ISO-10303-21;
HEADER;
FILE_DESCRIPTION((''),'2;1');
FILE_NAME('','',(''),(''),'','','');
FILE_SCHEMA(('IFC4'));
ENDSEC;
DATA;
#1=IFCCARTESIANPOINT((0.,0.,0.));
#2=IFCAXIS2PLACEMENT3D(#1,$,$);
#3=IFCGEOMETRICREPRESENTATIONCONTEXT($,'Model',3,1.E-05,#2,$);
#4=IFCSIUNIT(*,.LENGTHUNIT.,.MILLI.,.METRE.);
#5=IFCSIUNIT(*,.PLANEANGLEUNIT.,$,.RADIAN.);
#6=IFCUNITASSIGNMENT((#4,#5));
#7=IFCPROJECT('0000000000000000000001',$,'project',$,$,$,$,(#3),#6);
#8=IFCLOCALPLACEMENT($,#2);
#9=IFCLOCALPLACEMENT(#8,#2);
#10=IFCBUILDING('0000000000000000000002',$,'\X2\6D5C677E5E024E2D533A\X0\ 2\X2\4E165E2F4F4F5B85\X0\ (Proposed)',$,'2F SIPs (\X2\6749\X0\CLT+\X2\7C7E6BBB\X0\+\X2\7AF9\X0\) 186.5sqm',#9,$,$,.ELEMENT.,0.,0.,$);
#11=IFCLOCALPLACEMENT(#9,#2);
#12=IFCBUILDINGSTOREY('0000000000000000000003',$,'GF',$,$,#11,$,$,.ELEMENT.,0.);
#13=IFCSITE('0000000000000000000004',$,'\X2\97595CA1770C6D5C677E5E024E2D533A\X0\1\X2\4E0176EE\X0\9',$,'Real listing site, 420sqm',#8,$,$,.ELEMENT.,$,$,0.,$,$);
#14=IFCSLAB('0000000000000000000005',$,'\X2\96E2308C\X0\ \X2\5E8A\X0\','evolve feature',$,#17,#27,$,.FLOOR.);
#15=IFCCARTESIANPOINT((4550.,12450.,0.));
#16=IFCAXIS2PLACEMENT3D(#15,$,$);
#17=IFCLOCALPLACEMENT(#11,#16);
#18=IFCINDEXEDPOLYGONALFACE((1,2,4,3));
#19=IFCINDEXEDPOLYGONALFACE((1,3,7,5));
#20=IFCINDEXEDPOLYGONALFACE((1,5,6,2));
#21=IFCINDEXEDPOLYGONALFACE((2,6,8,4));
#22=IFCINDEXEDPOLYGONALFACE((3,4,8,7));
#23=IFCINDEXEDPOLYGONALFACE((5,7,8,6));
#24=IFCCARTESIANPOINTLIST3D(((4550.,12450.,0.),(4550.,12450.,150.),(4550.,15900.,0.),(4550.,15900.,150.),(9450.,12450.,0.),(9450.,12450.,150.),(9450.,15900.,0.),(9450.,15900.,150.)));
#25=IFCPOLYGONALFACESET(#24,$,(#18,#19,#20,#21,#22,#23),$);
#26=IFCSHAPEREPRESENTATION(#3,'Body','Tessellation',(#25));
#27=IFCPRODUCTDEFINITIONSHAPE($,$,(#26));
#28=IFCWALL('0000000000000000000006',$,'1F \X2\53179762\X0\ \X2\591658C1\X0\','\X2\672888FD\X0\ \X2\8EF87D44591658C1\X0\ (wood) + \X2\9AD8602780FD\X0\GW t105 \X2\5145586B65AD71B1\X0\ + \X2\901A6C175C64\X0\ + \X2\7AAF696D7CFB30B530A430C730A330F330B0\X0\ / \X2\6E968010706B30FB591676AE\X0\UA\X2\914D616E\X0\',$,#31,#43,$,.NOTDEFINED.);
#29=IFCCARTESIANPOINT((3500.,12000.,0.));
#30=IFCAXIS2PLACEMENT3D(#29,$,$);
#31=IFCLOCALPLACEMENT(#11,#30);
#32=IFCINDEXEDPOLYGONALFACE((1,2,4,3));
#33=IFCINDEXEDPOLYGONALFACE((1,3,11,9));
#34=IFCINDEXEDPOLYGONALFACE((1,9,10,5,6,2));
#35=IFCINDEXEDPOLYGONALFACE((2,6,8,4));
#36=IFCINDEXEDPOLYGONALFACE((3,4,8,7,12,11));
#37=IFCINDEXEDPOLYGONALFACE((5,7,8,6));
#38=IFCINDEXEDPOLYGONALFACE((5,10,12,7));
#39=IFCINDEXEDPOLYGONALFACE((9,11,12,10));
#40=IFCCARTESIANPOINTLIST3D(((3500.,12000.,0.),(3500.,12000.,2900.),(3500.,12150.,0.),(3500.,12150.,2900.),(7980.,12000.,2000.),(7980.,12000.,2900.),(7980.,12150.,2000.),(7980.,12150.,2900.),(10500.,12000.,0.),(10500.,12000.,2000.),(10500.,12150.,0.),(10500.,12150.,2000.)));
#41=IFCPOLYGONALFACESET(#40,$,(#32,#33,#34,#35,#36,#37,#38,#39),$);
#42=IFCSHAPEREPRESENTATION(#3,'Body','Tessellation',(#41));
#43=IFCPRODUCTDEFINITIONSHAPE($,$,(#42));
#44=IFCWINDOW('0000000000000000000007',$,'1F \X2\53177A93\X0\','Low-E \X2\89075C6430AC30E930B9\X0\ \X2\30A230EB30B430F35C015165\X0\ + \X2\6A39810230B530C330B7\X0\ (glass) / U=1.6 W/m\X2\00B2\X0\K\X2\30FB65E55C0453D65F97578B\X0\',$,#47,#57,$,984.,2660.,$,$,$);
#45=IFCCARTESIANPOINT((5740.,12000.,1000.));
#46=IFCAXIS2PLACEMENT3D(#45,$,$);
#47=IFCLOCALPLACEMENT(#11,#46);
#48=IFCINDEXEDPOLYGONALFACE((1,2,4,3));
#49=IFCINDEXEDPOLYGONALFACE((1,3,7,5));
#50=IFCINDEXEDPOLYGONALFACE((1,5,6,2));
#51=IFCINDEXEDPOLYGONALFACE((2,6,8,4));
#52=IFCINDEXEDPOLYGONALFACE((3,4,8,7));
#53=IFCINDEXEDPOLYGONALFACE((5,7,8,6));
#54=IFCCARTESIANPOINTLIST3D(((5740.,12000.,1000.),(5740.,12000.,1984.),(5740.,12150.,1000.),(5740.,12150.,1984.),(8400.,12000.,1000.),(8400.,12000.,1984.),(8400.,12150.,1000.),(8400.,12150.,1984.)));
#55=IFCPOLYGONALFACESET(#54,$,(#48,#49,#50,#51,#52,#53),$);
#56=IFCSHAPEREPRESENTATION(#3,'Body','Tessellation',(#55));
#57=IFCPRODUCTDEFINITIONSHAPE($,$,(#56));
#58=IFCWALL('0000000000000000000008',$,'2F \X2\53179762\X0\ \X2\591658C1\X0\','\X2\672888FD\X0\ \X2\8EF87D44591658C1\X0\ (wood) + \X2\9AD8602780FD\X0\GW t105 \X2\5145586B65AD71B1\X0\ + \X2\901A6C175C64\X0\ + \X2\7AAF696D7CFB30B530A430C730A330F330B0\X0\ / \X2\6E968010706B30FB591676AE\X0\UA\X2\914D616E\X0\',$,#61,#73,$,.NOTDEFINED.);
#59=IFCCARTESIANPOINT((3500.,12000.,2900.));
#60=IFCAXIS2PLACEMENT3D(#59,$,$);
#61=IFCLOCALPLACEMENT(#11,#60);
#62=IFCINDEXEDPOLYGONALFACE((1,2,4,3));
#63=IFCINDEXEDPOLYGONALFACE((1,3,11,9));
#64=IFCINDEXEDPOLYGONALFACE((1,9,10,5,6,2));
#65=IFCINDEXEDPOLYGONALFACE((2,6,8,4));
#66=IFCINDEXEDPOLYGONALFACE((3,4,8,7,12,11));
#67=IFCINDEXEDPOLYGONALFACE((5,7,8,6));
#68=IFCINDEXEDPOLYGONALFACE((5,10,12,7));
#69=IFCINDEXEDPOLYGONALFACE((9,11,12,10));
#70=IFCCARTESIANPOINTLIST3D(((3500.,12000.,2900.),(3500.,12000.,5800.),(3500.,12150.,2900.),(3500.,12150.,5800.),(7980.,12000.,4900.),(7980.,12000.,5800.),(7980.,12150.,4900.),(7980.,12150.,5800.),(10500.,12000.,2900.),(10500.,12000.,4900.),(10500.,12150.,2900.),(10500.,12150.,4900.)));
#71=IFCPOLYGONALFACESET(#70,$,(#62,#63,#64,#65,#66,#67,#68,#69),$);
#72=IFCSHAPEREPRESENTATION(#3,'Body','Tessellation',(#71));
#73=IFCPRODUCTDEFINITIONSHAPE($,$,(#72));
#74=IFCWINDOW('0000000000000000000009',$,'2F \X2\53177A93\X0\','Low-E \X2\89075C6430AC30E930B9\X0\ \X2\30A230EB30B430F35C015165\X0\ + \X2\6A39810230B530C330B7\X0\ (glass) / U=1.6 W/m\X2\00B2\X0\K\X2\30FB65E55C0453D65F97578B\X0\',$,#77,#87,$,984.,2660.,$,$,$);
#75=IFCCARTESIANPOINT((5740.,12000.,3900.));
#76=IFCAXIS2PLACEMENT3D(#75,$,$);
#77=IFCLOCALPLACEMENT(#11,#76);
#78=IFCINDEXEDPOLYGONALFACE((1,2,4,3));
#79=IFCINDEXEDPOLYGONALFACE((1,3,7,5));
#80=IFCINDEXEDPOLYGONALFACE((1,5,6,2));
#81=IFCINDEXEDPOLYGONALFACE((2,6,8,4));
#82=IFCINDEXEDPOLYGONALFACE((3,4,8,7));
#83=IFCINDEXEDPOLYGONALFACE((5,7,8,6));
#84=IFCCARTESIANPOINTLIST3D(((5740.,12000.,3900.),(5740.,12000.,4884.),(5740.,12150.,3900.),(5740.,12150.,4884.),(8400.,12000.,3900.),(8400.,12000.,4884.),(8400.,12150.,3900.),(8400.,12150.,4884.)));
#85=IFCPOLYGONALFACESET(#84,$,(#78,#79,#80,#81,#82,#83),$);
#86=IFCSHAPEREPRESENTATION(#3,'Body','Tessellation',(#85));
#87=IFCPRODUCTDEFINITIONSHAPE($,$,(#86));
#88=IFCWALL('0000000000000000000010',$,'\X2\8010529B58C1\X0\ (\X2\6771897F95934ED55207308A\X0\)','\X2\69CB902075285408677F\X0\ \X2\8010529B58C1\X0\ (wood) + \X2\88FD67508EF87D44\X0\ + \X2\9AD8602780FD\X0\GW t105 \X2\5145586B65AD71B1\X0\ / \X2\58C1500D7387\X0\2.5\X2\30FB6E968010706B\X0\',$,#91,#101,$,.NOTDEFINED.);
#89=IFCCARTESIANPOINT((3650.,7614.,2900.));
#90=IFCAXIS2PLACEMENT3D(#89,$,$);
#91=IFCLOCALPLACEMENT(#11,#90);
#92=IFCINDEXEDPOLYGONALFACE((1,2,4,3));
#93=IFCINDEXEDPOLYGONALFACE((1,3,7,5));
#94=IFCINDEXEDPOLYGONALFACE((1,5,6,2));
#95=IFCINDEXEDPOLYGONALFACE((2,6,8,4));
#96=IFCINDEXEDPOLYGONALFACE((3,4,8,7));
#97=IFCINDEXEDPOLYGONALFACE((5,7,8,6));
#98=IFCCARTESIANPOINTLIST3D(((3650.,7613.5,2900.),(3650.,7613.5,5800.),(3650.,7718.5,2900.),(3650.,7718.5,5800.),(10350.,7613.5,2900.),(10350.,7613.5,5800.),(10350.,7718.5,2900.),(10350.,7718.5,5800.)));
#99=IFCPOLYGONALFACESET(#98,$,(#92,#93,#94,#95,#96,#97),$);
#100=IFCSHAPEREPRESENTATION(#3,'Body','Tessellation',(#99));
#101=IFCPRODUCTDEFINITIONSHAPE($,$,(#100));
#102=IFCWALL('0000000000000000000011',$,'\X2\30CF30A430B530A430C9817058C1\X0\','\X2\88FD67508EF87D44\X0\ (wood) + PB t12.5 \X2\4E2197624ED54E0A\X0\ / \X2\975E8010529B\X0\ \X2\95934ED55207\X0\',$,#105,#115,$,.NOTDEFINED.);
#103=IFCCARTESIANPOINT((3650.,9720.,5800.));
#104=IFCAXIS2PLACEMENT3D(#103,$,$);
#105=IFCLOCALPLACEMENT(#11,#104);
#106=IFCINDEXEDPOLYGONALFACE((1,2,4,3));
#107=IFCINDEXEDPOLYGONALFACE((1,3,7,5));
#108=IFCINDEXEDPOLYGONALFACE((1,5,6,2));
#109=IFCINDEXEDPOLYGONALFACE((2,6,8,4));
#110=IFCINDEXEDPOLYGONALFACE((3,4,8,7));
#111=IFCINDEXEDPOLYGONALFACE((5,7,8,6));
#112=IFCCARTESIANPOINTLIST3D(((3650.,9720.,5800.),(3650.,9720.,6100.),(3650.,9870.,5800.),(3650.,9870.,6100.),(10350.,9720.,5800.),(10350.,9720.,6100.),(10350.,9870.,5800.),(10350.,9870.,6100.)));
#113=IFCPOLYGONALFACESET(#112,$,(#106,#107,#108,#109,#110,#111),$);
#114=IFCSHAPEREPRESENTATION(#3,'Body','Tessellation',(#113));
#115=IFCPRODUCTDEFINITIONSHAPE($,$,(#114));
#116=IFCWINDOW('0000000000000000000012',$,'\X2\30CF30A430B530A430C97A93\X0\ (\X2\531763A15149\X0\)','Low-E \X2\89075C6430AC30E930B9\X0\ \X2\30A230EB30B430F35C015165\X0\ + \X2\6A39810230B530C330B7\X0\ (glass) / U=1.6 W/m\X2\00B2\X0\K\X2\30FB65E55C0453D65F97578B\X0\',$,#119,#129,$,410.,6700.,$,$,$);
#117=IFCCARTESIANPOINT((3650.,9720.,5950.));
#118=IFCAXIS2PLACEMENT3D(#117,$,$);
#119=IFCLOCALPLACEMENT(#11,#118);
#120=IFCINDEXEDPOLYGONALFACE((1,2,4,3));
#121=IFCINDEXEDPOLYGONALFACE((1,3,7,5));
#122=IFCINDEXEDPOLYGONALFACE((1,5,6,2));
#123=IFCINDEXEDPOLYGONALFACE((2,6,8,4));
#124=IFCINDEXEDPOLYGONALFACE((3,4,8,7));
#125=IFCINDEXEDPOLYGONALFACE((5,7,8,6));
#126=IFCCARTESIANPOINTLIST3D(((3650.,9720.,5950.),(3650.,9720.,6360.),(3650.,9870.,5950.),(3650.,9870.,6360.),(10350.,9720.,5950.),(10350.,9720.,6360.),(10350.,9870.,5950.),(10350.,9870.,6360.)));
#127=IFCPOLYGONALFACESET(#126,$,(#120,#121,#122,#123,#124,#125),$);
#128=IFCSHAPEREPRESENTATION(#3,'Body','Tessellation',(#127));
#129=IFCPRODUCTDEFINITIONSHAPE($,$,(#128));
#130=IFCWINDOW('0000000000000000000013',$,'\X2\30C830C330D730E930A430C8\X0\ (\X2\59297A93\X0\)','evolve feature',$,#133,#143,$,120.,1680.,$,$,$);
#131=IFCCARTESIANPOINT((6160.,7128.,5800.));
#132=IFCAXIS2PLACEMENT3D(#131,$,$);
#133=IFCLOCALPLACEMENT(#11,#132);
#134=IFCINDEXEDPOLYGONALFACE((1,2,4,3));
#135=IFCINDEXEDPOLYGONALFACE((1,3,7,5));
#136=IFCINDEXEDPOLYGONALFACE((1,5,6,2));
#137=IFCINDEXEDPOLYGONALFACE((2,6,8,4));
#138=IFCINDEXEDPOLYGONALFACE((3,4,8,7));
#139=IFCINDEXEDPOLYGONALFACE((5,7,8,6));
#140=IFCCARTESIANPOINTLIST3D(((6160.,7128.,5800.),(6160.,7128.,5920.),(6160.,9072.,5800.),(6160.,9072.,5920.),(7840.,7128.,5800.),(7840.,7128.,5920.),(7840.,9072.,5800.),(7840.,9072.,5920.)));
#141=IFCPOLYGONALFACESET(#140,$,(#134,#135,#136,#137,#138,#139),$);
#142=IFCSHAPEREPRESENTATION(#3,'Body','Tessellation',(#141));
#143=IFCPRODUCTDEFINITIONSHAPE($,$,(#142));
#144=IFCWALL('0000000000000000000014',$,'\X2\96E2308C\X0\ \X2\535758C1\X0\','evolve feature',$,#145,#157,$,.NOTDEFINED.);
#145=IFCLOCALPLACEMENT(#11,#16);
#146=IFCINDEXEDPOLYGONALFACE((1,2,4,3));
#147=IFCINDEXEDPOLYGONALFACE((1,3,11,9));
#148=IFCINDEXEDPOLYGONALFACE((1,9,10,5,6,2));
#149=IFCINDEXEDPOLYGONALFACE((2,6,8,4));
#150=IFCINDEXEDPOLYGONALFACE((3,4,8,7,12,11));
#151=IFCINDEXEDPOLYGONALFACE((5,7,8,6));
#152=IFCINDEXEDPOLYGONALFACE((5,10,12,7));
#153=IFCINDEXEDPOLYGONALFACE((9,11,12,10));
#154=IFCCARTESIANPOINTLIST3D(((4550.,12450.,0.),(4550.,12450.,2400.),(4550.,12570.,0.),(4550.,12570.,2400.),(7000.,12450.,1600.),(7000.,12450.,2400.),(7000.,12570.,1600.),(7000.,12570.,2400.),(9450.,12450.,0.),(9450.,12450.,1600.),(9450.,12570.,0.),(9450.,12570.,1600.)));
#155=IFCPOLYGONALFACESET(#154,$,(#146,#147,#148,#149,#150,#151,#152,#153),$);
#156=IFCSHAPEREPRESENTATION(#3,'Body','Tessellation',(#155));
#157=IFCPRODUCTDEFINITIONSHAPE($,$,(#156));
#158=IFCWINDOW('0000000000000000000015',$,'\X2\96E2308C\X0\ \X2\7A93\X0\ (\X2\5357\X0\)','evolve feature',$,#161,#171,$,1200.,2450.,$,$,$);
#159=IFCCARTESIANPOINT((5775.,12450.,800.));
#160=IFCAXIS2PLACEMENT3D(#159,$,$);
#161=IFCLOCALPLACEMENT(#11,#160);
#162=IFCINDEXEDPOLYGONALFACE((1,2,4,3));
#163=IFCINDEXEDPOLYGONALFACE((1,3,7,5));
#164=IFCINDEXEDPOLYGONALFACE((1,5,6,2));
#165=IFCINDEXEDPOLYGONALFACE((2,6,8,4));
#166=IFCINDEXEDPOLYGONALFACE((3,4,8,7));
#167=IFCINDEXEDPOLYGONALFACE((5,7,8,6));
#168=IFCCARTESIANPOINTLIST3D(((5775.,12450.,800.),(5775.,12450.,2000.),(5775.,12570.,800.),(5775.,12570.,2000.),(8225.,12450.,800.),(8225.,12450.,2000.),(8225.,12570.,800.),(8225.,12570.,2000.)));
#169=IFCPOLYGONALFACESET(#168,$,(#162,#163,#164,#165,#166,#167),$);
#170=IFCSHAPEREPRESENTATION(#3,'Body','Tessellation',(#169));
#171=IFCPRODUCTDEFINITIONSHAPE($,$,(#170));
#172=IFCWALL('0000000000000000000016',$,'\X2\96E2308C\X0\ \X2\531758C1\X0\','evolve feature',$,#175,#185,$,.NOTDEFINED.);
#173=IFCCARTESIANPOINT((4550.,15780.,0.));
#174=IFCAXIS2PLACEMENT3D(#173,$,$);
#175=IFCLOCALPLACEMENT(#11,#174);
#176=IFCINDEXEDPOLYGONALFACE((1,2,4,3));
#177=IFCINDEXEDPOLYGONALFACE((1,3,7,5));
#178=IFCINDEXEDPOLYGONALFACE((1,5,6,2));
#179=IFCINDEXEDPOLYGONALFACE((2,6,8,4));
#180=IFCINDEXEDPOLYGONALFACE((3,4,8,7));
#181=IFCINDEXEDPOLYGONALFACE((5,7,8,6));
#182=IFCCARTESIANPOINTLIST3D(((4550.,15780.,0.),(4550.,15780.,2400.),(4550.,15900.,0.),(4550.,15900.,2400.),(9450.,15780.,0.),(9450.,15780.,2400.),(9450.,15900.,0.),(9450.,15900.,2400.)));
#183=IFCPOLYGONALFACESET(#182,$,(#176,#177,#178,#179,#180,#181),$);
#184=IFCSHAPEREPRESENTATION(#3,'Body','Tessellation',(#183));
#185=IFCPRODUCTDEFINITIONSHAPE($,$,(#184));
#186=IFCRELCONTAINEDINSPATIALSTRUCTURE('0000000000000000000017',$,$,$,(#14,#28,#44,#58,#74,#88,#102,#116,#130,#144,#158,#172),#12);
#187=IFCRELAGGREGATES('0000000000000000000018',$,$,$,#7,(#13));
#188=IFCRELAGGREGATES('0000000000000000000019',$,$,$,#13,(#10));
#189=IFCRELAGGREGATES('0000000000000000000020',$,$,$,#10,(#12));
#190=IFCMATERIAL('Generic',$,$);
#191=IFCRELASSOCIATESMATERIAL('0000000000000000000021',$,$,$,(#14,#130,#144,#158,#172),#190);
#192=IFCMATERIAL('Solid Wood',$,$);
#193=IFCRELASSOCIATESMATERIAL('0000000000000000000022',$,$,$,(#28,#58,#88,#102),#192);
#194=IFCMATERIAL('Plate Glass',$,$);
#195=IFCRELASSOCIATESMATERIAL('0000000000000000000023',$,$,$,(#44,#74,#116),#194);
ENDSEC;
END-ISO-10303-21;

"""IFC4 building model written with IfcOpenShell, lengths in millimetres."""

from ifc_helpers import new_model, si_unit, frame, frame_2d, origin, place, context, project, spatial, rectangle, extrude, material, element, fill, save


model = new_model("IFC4")

# Units and contexts
model_context = context("Model", 3, precision=1e-05, world=origin())
ifc_project = project(units=[si_unit("LENGTHUNIT", "METRE", prefix="MILLI"), si_unit("PLANEANGLEUNIT", "RADIAN")], contexts=[model_context])

# Site, building, storey
site_placement = place(None, origin())
site = spatial("IfcSite", under=ifc_project, at=site_placement, Name="静岡県浜松市中区1丁目9", ObjectType="Real listing site, 420sqm", CompositionType="ELEMENT", RefElevation=0.0)
building_placement = place(site_placement, origin())
building = spatial("IfcBuilding", under=site, at=building_placement, Name="浜松市中区 2世帯住宅 (Proposed)", ObjectType="2F SIPs (杉CLT+籾殻+竹) 186.5sqm", CompositionType="ELEMENT", ElevationOfRefHeight=0.0, ElevationOfTerrain=0.0)
storey_placement = place(building_placement, origin())
storey = spatial("IfcBuildingStorey", under=building, at=storey_placement, Name="GF", CompositionType="ELEMENT", Elevation=0.0)

# Slab
ifc_material_1 = material(Name="Generic")
slab_placement = place(storey_placement, frame((4550.0, 12450.0, 0.0)))
element("IfcSlab", 1, at=slab_placement, inside=storey, material=ifc_material_1, Name="離れ 床", Description="evolve feature", PredefinedType="FLOOR", context=model_context, shape_type="SweptSolid", body=[
    extrude(rectangle(XDim=4900.0, YDim=3450.0, at=frame_2d((2450.0, 1725.0))), frame((4550.0, 12450.0, 0.0)), (0.0, 0.0, 1.0), 150.0),
])

# Wall, opening, window
ifc_material_2 = material(Name="Solid Wood")
wall_1_placement = place(storey_placement, frame((3500.0, 12000.0, 0.0)))
wall_1 = element("IfcWall", 2, at=wall_1_placement, inside=storey, material=ifc_material_2, Name="1F 北面 外壁", Description="木製 軸組外壁 (wood) + 高性能GW t105 充填断熱 + 通気層 + 窯業系サイディング / 準耐火・外皮UA配慮", PredefinedType="NOTDEFINED", context=model_context, shape_type="SweptSolid", body=[
    extrude(rectangle(XDim=7000.0, YDim=150.0, at=frame_2d((3500.0, 75.0))), frame((3500.0, 12000.0, 0.0)), (0.0, 0.0, 1.0), 2900.0),
])
opening_1_placement = place(storey_placement, frame((5740.0, 12000.0, 1000.0)))
opening_1 = element("IfcOpeningElement", 3, at=opening_1_placement, cuts=wall_1, PredefinedType="NOTDEFINED", context=model_context, shape_type="SweptSolid", body=[
    extrude(rectangle(XDim=2660.0, YDim=150.0, at=frame_2d((1330.0, 75.0))), frame((5740.0, 12000.0, 1000.0)), (0.0, 0.0, 1.0), 984.0),
])
ifc_material_3 = material(Name="Plate Glass")
window_1_placement = place(storey_placement, frame((5740.0, 12000.0, 1000.0)))
window_1 = element("IfcWindow", 4, at=window_1_placement, inside=storey, material=ifc_material_3, Name="1F 北窓", Description="Low-E 複層ガラス アルゴン封入 + 樹脂サッシ (glass) / U=1.6 W/m²K・日射取得型", OverallHeight=984.0, OverallWidth=2660.0, context=model_context, shape_type="SweptSolid", body=[
    extrude(rectangle(XDim=2660.0, YDim=150.0, at=frame_2d((1330.0, 75.0))), frame((5740.0, 12000.0, 1000.0)), (0.0, 0.0, 1.0), 984.0),
])
fill(opening_1, window_1)

# Wall, opening, window
wall_2_placement = place(storey_placement, frame((3500.0, 12000.0, 2900.0)))
wall_2 = element("IfcWall", 5, at=wall_2_placement, inside=storey, material=ifc_material_2, Name="2F 北面 外壁", Description="木製 軸組外壁 (wood) + 高性能GW t105 充填断熱 + 通気層 + 窯業系サイディング / 準耐火・外皮UA配慮", PredefinedType="NOTDEFINED", context=model_context, shape_type="SweptSolid", body=[
    extrude(rectangle(XDim=7000.0, YDim=150.0, at=frame_2d((3500.0, 75.0))), frame((3500.0, 12000.0, 2900.0)), (0.0, 0.0, 1.0), 2900.0),
])
opening_2_placement = place(storey_placement, frame((5740.0, 12000.0, 3900.0)))
opening_2 = element("IfcOpeningElement", 6, at=opening_2_placement, cuts=wall_2, PredefinedType="NOTDEFINED", context=model_context, shape_type="SweptSolid", body=[
    extrude(rectangle(XDim=2660.0, YDim=150.0, at=frame_2d((1330.0, 75.0))), frame((5740.0, 12000.0, 3900.0)), (0.0, 0.0, 1.0), 984.0),
])
window_2_placement = place(storey_placement, frame((5740.0, 12000.0, 3900.0)))
window_2 = element("IfcWindow", 7, at=window_2_placement, inside=storey, material=ifc_material_3, Name="2F 北窓", Description="Low-E 複層ガラス アルゴン封入 + 樹脂サッシ (glass) / U=1.6 W/m²K・日射取得型", OverallHeight=984.0, OverallWidth=2660.0, context=model_context, shape_type="SweptSolid", body=[
    extrude(rectangle(XDim=2660.0, YDim=150.0, at=frame_2d((1330.0, 75.0))), frame((5740.0, 12000.0, 3900.0)), (0.0, 0.0, 1.0), 984.0),
])
fill(opening_2, window_2)

# Wall
wall_3_placement = place(storey_placement, frame((3650.0, 7614.0, 2900.0)))
element("IfcWall", 8, at=wall_3_placement, inside=storey, material=ifc_material_2, Name="耐力壁 (東西間仕切り)", Description="構造用合板 耐力壁 (wood) + 製材軸組 + 高性能GW t105 充填断熱 / 壁倍率2.5・準耐火", PredefinedType="NOTDEFINED", context=model_context, shape_type="SweptSolid", body=[
    extrude(rectangle(XDim=6700.0, YDim=105.0, at=frame_2d((3350.0, 52.0))), frame((3650.0, 7614.0, 2900.0)), (0.0, 0.0, 1.0), 2900.0),
])

# Wall, opening, window
wall_4_placement = place(storey_placement, frame((3650.0, 9720.0, 5800.0)))
wall_4 = element("IfcWall", 9, at=wall_4_placement, inside=storey, material=ifc_material_2, Name="ハイサイド腰壁", Description="製材軸組 (wood) + PB t12.5 両面仕上 / 非耐力 間仕切", PredefinedType="NOTDEFINED", context=model_context, shape_type="SweptSolid", body=[
    extrude(rectangle(XDim=6700.0, YDim=150.0, at=frame_2d((3350.0, 75.0))), frame((3650.0, 9720.0, 5800.0)), (0.0, 0.0, 1.0), 700.0),
])
opening_3_placement = place(storey_placement, frame((3650.0, 9720.0, 5950.0)))
opening_3 = element("IfcOpeningElement", 10, at=opening_3_placement, cuts=wall_4, PredefinedType="NOTDEFINED", context=model_context, shape_type="SweptSolid", body=[
    extrude(rectangle(XDim=6700.0, YDim=150.0, at=frame_2d((3350.0, 75.0))), frame((3650.0, 9720.0, 5950.0)), (0.0, 0.0, 1.0), 410.0),
])
window_3_placement = place(storey_placement, frame((3650.0, 9720.0, 5950.0)))
window_3 = element("IfcWindow", 11, at=window_3_placement, inside=storey, material=ifc_material_3, Name="ハイサイド窓 (北採光)", Description="Low-E 複層ガラス アルゴン封入 + 樹脂サッシ (glass) / U=1.6 W/m²K・日射取得型", OverallHeight=410.0, OverallWidth=6700.0, context=model_context, shape_type="SweptSolid", body=[
    extrude(rectangle(XDim=6700.0, YDim=150.0, at=frame_2d((3350.0, 75.0))), frame((3650.0, 9720.0, 5950.0)), (0.0, 0.0, 1.0), 410.0),
])
fill(opening_3, window_3)

# Window
window_4_placement = place(storey_placement, frame((6160.0, 7128.0, 5800.0)))
element("IfcWindow", 12, at=window_4_placement, inside=storey, material=ifc_material_1, Name="トップライト (天窓)", Description="evolve feature", OverallHeight=120.0, OverallWidth=1680.0, context=model_context, shape_type="SweptSolid", body=[
    extrude(rectangle(XDim=1680.0, YDim=1944.0, at=frame_2d((840.0, 972.0))), frame((6160.0, 7128.0, 5800.0)), (0.0, 0.0, 1.0), 120.0),
])

# Wall, opening, window
wall_5_placement = place(storey_placement, frame((4550.0, 12450.0, 0.0)))
wall_5 = element("IfcWall", 13, at=wall_5_placement, inside=storey, material=ifc_material_1, Name="離れ 南壁", Description="evolve feature", PredefinedType="NOTDEFINED", context=model_context, shape_type="SweptSolid", body=[
    extrude(rectangle(XDim=4900.0, YDim=120.0, at=frame_2d((2450.0, 60.0))), frame((4550.0, 12450.0, 0.0)), (0.0, 0.0, 1.0), 2400.0),
])
opening_4_placement = place(storey_placement, frame((5775.0, 12450.0, 800.0)))
opening_4 = element("IfcOpeningElement", 14, at=opening_4_placement, cuts=wall_5, PredefinedType="NOTDEFINED", context=model_context, shape_type="SweptSolid", body=[
    extrude(rectangle(XDim=2450.0, YDim=120.0, at=frame_2d((1225.0, 60.0))), frame((5775.0, 12450.0, 800.0)), (0.0, 0.0, 1.0), 1200.0),
])
window_5_placement = place(storey_placement, frame((5775.0, 12450.0, 800.0)))
window_5 = element("IfcWindow", 15, at=window_5_placement, inside=storey, material=ifc_material_1, Name="離れ 窓 (南)", Description="evolve feature", OverallHeight=1200.0, OverallWidth=2450.0, context=model_context, shape_type="SweptSolid", body=[
    extrude(rectangle(XDim=2450.0, YDim=120.0, at=frame_2d((1225.0, 60.0))), frame((5775.0, 12450.0, 800.0)), (0.0, 0.0, 1.0), 1200.0),
])
fill(opening_4, window_5)

# Wall
wall_6_placement = place(storey_placement, frame((4550.0, 15780.0, 0.0)))
element("IfcWall", 16, at=wall_6_placement, inside=storey, material=ifc_material_1, Name="離れ 北壁", Description="evolve feature", PredefinedType="NOTDEFINED", context=model_context, shape_type="SweptSolid", body=[
    extrude(rectangle(XDim=4900.0, YDim=120.0, at=frame_2d((2450.0, 60.0))), frame((4550.0, 15780.0, 0.0)), (0.0, 0.0, 1.0), 2400.0),
])

save(model, "model.ifc")
